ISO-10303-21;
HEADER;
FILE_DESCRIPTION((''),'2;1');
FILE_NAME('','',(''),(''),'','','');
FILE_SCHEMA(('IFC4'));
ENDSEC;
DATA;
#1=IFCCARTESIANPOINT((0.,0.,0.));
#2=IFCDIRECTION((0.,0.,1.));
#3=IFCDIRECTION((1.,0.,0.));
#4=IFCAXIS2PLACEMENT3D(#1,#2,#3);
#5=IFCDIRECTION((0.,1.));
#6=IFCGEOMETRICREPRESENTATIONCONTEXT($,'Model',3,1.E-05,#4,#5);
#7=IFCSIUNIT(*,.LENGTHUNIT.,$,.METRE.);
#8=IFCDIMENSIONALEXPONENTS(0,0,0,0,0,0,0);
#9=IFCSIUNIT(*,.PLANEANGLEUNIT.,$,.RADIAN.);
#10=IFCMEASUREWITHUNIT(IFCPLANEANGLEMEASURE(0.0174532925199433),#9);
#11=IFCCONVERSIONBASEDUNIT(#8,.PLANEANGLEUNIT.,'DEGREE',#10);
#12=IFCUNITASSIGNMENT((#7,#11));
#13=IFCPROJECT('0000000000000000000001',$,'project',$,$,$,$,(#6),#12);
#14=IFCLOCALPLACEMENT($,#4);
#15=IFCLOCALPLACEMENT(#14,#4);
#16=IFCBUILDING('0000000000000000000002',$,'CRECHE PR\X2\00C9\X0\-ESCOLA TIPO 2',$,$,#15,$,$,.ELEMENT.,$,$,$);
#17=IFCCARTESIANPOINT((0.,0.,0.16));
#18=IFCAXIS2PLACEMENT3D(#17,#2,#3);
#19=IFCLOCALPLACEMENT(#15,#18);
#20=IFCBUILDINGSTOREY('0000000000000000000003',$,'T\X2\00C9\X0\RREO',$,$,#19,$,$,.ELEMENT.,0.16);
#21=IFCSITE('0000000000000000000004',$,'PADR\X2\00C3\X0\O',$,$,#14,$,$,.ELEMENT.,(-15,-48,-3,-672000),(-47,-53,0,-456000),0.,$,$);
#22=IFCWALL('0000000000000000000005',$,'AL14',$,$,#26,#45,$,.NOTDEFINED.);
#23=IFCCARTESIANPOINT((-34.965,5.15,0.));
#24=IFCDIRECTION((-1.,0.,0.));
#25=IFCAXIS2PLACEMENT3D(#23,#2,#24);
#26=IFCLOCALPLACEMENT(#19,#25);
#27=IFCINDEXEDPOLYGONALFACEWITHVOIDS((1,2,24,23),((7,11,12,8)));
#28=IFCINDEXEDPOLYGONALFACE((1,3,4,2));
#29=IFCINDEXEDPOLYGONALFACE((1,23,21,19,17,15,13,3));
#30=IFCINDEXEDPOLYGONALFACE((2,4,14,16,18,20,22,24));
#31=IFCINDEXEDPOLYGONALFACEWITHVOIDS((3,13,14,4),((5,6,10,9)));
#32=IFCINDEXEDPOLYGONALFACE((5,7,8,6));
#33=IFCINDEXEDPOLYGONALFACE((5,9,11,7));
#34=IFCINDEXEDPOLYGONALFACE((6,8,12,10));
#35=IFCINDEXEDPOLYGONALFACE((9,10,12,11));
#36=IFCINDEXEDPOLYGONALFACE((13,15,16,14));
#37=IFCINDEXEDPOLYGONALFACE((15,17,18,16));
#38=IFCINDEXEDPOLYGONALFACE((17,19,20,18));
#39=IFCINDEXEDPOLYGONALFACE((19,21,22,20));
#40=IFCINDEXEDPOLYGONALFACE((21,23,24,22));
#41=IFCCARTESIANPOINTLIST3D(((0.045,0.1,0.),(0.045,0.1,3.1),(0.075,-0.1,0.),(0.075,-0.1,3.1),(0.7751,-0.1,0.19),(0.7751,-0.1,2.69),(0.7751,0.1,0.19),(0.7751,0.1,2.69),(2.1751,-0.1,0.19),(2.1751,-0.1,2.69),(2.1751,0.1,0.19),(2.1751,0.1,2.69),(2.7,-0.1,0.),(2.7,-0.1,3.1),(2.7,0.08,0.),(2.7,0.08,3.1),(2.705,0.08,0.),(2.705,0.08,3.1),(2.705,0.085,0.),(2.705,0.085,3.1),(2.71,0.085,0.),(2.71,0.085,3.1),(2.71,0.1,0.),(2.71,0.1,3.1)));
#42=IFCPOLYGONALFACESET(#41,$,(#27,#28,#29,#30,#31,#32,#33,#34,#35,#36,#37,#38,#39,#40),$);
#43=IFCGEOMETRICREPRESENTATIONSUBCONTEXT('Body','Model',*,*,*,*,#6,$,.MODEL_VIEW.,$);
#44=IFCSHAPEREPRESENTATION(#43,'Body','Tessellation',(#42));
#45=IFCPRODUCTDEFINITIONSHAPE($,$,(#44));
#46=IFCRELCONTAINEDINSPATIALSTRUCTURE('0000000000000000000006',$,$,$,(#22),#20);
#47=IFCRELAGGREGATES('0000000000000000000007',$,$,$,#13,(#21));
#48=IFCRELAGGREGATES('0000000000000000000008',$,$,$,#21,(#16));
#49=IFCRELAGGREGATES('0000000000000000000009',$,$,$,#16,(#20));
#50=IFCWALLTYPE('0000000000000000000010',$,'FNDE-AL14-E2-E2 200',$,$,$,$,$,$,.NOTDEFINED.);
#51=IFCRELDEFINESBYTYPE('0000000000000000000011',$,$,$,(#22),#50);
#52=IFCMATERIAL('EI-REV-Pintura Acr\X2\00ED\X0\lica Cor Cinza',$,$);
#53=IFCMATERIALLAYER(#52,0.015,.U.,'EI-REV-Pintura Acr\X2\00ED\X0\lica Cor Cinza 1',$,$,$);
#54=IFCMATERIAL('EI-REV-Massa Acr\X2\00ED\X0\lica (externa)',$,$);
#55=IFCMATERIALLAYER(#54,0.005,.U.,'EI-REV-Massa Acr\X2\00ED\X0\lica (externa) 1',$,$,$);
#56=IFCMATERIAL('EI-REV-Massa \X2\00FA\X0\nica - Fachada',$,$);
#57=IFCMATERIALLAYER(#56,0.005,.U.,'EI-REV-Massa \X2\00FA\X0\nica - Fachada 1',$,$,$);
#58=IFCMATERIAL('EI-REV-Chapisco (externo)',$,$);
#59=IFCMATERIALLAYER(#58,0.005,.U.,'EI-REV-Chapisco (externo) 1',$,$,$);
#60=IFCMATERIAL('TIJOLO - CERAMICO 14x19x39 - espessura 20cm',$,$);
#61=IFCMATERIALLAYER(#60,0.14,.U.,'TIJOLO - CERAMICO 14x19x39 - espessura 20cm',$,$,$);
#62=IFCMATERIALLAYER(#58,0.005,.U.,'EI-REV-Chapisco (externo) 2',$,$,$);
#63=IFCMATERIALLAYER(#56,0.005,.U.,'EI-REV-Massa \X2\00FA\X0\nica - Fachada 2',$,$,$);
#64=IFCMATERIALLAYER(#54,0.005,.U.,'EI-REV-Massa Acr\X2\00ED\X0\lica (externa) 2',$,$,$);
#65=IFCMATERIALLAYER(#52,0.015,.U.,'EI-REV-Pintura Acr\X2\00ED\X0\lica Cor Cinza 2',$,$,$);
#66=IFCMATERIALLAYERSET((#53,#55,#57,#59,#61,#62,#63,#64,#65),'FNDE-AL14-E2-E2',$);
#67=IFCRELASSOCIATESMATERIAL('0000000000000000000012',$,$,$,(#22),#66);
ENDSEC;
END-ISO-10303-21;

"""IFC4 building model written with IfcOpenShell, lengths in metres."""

from ifc_helpers import new_model, entity, si_unit, converted_unit, direction, frame, origin_with_axes, origin_2d_with_axis, place, context, subcontext, project, spatial, line, indexed_curve, rectangle, outline, extrude, material, layer, layer_set, layer_usage, type_object, element, save


model = new_model("IFC4")

# Units and contexts
model_context = context("Model", 3, precision=1e-05, world=origin_with_axes(), true_north=direction((0.0, 1.0)))
body_context = subcontext(model_context, "Body", "Model", "MODEL_VIEW")
ifc_project = project(units=[si_unit("LENGTHUNIT", "METRE"), converted_unit("PLANEANGLEUNIT", "DEGREE", entity("IfcPlaneAngleMeasure", 0.0174532925199433), si_unit("PLANEANGLEUNIT", "RADIAN"), dimensions=[0, 0, 0, 0, 0, 0, 0])], contexts=[model_context])

# Site, building, storey
site_placement = place(None, origin_with_axes())
site = spatial("IfcSite", under=ifc_project, at=site_placement, Name="PADRÃO", CompositionType="ELEMENT", RefLatitude=(-15, -48, -3, -672000), RefLongitude=(-47, -53, 0, -456000), RefElevation=0.0)
building_placement = place(site_placement, origin_with_axes())
building = spatial("IfcBuilding", under=site, at=building_placement, Name="CRECHE PRÉ-ESCOLA TIPO 2", CompositionType="ELEMENT")
storey_placement = place(building_placement, frame((0.0, 0.0, 0.16), z_axis=(0.0, 0.0, 1.0), x_axis=(1.0, 0.0, 0.0)))
storey = spatial("IfcBuildingStorey", under=building, at=storey_placement, Name="TÉRREO", CompositionType="ELEMENT", Elevation=0.16)

# Shared definitions
ifc_material_1 = material(Name="EI-REV-Pintura Acrílica Cor Cinza")

# Wall, openings
ifc_layer_1 = layer(ifc_material_1, 0.015, ventilated="UNKNOWN", Name="EI-REV-Pintura Acrílica Cor Cinza 1")
ifc_material_2 = material(Name="EI-REV-Massa Acrílica (externa)")
ifc_layer_2 = layer(ifc_material_2, 0.005, ventilated="UNKNOWN", Name="EI-REV-Massa Acrílica (externa) 1")
ifc_material_3 = material(Name="EI-REV-Massa única - Fachada")
ifc_layer_3 = layer(ifc_material_3, 0.005, ventilated="UNKNOWN", Name="EI-REV-Massa única - Fachada 1")
ifc_material_4 = material(Name="EI-REV-Chapisco (externo)")
ifc_layer_4 = layer(ifc_material_4, 0.005, ventilated="UNKNOWN", Name="EI-REV-Chapisco (externo) 1")
ifc_material_5 = material(Name="TIJOLO - CERAMICO 14x19x39 - espessura 20cm")
ifc_layer_5 = layer(ifc_material_5, 0.14, ventilated="UNKNOWN", Name="TIJOLO - CERAMICO 14x19x39 - espessura 20cm")
ifc_layer_6 = layer(ifc_material_4, 0.005, ventilated="UNKNOWN", Name="EI-REV-Chapisco (externo) 2")
ifc_layer_7 = layer(ifc_material_3, 0.005, ventilated="UNKNOWN", Name="EI-REV-Massa única - Fachada 2")
ifc_layer_8 = layer(ifc_material_2, 0.005, ventilated="UNKNOWN", Name="EI-REV-Massa Acrílica (externa) 2")
ifc_layer_9 = layer(ifc_material_1, 0.015, ventilated="UNKNOWN", Name="EI-REV-Pintura Acrílica Cor Cinza 2")
ifc_layer_set_1 = layer_set([ifc_layer_1, ifc_layer_2, ifc_layer_3, ifc_layer_4, ifc_layer_5, ifc_layer_6, ifc_layer_7, ifc_layer_8, ifc_layer_9], Name="FNDE-AL14-E2-E2")
ifc_layer_usage_1 = layer_usage(ifc_layer_set_1, "AXIS2", "POSITIVE", -0.1)
wall_type_1 = type_object("IfcWallType", Name="FNDE-AL14-E2-E2 200", PredefinedType="NOTDEFINED")
wall_1_placement = place(storey_placement, frame((-34.965, 5.15, 0.0), z_axis=(0.0, 0.0, 1.0), x_axis=(-1.0, 0.0, 0.0)))
wall_1 = element("IfcWall", 1, at=wall_1_placement, inside=storey, type_object=wall_type_1, material=ifc_layer_usage_1, Name="AL14", PredefinedType="NOTDEFINED", context=body_context, shape_type="SweptSolid", body=[
    extrude(outline(indexed_curve([(0.075, -0.1), (2.725, -0.1), (2.725, 0.1), (0.045, 0.1)], segments=[line(1, 2, 3, 4, 1)])), origin_with_axes(), (0.0, 0.0, 1.0), 3.1),
])
opening_1_placement = place(wall_1_placement, frame((1.4751, 0.0, 0.19), z_axis=(0.0, 0.0, 1.0), x_axis=(1.0, 0.0, 0.0)))
element("IfcOpeningElement", 2, at=opening_1_placement, cuts=wall_1, context=body_context, shape_type="SweptSolid", body=[
    extrude(rectangle(XDim=1.4, YDim=2.5, at=origin_2d_with_axis()), frame((0.0, -0.07, 1.25), z_axis=(0.0, -1.0, 0.0), x_axis=(-1.0, 0.0, 0.0)), (0.0, 0.0, -1.0), 0.37),
    extrude(rectangle(XDim=1.4, YDim=2.5, at=origin_2d_with_axis()), frame((0.0, -0.07, 1.25), z_axis=(0.0, 1.0, 0.0), x_axis=(-1.0, 0.0, 0.0)), (0.0, 0.0, -1.0), 0.23),
])
opening_2_placement = place(wall_1_placement, frame((2.725, 0.0, 0.0), z_axis=(0.0, 0.0, 1.0), x_axis=(1.0, 0.0, 0.0)))
element("IfcOpeningElement", 3, at=opening_2_placement, cuts=wall_1, context=body_context, shape_type="SweptSolid", body=[
    extrude(rectangle(XDim=0.2, YDim=0.015, at=origin_2d_with_axis()), frame((-0.0075, 0.0, 0.0), z_axis=(0.0, 0.0, 1.0), x_axis=(0.0, -1.0, 0.0)), (0.0, 0.0, 1.0), 3.1),
    extrude(rectangle(XDim=0.185, YDim=0.005, at=origin_2d_with_axis()), frame((-0.0175, -0.0075, 0.0), z_axis=(0.0, 0.0, 1.0), x_axis=(0.0, -1.0, 0.0)), (0.0, 0.0, 1.0), 3.1),
    extrude(rectangle(XDim=0.18, YDim=0.005, at=origin_2d_with_axis()), frame((-0.0225, -0.01, 0.0), z_axis=(0.0, 0.0, 1.0), x_axis=(0.0, -1.0, 0.0)), (0.0, 0.0, 1.0), 3.1),
])

save(model, "model.ifc")
